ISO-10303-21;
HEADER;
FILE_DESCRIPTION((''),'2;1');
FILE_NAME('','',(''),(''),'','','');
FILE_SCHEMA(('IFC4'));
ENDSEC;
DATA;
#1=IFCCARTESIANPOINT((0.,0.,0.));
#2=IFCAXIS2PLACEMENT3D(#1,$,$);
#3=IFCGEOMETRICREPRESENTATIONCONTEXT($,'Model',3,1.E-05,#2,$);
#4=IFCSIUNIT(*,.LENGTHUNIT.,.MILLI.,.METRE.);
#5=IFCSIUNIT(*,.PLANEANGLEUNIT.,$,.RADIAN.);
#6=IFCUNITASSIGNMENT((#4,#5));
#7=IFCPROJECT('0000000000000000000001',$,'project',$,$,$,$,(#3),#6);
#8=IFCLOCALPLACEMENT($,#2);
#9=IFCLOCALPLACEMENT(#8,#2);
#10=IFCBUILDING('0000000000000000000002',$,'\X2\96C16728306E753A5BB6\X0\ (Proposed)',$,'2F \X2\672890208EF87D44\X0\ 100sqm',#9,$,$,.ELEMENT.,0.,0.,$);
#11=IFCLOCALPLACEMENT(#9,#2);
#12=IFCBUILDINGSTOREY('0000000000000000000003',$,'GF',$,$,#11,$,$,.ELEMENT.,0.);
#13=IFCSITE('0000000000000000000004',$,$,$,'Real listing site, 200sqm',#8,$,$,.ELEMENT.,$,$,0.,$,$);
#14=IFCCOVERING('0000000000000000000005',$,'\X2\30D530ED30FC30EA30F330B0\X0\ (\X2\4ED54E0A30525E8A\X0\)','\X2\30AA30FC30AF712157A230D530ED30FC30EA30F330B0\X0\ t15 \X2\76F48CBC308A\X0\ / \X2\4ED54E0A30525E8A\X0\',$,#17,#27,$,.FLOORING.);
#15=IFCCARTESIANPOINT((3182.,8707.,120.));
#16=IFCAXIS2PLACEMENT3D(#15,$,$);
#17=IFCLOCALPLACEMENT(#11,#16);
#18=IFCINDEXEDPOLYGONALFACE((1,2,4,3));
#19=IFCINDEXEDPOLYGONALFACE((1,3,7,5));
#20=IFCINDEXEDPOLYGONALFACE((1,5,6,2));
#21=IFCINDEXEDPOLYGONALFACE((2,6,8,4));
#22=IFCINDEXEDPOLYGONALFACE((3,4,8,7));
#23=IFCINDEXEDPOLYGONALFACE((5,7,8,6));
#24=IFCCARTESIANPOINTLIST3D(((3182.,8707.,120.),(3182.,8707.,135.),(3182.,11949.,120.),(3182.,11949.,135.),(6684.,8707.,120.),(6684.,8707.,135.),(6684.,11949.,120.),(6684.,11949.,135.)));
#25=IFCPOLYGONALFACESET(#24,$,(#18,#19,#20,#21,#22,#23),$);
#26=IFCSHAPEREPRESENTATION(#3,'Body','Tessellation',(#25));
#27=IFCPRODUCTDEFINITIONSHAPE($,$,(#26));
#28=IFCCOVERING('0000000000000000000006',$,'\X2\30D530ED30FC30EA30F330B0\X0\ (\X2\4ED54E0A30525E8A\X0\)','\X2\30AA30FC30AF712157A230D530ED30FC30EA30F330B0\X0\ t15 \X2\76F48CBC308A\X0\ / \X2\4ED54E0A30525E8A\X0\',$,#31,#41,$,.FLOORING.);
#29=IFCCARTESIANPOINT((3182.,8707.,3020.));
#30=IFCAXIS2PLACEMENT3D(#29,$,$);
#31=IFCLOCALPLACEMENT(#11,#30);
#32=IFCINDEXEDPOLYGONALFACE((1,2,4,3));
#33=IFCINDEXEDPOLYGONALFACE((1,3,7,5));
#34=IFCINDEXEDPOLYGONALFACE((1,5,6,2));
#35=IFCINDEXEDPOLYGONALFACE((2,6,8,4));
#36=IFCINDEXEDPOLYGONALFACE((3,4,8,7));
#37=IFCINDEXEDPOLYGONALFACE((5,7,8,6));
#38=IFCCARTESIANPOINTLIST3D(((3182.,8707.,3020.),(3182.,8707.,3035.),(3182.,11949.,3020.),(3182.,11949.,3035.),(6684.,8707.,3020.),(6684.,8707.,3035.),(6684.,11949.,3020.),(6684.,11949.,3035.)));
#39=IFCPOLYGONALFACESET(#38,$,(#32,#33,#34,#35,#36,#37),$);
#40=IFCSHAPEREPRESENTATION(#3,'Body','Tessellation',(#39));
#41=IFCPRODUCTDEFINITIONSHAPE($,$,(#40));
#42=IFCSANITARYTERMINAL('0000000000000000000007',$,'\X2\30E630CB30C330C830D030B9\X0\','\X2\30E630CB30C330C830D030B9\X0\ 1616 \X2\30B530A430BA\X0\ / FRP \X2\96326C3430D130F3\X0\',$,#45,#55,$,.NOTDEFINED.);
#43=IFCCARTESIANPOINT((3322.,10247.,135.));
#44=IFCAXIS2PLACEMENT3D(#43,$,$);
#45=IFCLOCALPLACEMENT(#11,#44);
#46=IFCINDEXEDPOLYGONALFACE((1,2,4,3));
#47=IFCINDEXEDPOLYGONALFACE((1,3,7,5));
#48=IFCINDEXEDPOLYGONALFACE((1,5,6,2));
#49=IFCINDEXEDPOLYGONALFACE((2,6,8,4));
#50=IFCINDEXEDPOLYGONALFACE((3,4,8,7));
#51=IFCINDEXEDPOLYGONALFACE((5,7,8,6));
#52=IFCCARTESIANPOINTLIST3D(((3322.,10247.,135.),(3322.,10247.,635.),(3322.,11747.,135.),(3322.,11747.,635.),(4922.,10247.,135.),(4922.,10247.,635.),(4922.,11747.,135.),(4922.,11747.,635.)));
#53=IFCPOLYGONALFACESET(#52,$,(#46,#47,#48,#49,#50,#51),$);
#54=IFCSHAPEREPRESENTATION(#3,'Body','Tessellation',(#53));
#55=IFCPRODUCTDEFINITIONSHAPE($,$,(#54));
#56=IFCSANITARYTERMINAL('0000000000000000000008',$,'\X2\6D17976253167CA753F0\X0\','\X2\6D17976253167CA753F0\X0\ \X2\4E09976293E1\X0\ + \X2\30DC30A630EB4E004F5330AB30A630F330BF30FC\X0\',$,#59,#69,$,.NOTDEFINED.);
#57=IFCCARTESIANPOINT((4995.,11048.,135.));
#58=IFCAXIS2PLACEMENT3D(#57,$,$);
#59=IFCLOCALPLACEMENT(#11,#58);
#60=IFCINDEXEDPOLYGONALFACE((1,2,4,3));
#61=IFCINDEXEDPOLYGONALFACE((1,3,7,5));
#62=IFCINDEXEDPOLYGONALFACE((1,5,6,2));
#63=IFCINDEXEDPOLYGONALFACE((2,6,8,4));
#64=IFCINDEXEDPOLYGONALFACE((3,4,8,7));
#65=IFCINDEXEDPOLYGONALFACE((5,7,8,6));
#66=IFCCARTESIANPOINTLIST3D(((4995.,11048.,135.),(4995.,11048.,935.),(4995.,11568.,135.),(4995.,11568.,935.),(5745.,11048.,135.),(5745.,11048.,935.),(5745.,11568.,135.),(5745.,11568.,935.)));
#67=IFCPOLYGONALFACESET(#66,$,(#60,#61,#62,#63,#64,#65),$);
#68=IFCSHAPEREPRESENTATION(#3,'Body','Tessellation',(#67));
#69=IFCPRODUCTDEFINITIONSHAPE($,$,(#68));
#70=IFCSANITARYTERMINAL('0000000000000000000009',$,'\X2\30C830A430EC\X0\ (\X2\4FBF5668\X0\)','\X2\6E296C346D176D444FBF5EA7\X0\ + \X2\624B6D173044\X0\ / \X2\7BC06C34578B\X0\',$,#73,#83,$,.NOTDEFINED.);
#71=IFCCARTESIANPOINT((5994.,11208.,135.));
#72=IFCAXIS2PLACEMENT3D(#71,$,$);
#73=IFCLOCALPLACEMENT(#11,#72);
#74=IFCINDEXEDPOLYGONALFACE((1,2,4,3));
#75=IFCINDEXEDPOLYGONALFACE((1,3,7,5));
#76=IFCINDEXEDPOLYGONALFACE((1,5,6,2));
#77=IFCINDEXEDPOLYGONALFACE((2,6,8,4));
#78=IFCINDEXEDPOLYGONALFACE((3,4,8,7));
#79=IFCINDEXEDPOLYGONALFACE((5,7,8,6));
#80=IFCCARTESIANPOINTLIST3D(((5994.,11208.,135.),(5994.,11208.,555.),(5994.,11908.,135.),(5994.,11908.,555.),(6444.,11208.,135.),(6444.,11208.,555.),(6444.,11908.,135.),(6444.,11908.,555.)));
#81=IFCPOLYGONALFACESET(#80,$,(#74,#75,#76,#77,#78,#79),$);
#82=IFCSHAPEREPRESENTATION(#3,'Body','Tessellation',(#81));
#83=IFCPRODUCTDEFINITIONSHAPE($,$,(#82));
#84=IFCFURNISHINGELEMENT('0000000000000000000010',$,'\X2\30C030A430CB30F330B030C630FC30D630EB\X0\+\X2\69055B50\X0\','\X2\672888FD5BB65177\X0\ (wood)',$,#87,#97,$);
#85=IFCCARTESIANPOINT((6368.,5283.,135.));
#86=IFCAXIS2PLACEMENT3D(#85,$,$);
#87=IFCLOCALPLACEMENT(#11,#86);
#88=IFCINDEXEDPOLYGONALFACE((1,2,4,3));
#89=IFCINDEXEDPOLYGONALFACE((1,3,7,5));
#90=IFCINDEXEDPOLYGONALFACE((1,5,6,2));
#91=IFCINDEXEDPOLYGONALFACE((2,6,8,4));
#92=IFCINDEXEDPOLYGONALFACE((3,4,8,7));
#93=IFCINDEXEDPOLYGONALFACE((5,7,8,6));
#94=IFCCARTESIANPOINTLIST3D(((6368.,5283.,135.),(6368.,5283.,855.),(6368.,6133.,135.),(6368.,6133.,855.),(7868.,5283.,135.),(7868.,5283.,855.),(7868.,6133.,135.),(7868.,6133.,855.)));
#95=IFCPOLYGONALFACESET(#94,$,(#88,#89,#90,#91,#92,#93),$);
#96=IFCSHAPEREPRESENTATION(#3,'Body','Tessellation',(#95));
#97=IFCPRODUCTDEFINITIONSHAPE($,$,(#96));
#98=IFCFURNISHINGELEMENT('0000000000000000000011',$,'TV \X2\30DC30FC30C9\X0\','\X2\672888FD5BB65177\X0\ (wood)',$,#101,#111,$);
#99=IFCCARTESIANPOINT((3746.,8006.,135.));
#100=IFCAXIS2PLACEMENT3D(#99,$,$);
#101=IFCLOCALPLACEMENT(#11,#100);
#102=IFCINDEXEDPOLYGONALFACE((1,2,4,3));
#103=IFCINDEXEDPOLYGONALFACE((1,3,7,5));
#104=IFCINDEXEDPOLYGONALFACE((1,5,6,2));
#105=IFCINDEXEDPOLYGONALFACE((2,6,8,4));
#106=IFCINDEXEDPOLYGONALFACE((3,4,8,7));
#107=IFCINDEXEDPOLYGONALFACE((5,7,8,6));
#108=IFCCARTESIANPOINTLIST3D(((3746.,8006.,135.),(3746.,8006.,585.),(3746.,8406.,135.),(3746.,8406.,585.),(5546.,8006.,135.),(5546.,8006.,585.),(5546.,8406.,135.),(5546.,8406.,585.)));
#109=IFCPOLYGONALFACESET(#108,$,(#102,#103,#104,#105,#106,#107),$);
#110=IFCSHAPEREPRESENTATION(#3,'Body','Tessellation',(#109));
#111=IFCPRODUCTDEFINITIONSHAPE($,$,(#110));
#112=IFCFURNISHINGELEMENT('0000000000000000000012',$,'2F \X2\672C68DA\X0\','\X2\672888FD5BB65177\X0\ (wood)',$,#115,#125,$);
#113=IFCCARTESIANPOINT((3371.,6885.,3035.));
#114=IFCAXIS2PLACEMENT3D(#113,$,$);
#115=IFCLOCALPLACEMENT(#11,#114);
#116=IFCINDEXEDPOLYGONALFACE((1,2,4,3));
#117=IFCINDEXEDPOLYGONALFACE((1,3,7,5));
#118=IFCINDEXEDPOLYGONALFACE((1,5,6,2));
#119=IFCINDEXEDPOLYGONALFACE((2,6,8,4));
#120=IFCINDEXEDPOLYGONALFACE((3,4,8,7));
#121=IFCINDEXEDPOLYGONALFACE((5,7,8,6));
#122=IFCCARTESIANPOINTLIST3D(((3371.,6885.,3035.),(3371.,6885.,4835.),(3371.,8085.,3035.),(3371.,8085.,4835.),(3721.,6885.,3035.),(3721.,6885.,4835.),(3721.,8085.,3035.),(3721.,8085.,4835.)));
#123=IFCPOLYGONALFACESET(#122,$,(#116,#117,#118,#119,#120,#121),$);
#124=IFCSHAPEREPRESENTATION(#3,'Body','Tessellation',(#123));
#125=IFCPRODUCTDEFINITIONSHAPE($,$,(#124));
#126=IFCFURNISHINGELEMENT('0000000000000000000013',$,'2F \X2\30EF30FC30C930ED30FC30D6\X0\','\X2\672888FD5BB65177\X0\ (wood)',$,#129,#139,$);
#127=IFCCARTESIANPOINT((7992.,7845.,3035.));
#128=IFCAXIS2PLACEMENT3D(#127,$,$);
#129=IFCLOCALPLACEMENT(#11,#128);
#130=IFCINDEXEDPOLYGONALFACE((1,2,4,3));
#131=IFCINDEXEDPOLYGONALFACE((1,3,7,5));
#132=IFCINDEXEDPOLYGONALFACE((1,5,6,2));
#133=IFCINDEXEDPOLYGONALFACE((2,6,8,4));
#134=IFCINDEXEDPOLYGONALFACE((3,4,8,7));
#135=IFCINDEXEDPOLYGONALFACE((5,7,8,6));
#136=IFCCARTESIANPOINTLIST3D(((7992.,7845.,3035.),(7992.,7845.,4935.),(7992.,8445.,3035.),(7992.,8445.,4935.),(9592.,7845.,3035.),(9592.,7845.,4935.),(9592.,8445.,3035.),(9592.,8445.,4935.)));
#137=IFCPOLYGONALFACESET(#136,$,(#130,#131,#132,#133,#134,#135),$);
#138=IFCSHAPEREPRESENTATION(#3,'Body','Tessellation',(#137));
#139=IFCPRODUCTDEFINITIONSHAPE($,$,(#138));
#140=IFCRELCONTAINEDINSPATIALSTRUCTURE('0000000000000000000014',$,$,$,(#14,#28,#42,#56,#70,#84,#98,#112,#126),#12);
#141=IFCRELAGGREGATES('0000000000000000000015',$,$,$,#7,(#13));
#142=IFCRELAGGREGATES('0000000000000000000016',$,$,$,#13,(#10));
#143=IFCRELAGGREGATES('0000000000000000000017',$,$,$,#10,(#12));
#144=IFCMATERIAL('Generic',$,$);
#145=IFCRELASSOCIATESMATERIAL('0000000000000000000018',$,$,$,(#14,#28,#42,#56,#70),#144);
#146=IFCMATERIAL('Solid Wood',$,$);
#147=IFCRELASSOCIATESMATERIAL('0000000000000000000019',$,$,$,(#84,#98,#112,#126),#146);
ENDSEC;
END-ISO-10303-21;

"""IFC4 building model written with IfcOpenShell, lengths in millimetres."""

from ifc_helpers import new_model, si_unit, frame, frame_2d, origin, place, context, project, spatial, rectangle, extrude, material, element, save


model = new_model("IFC4")

# Units and contexts
model_context = context("Model", 3, precision=1e-05, world=origin())
ifc_project = project(units=[si_unit("LENGTHUNIT", "METRE", prefix="MILLI"), si_unit("PLANEANGLEUNIT", "RADIAN")], contexts=[model_context])

# Site, building, storey
site_placement = place(None, origin())
site = spatial("IfcSite", under=ifc_project, at=site_placement, ObjectType="Real listing site, 200sqm", CompositionType="ELEMENT", RefElevation=0.0)
building_placement = place(site_placement, origin())
building = spatial("IfcBuilding", under=site, at=building_placement, Name="雁木の町家 (Proposed)", ObjectType="2F 木造軸組 100sqm", CompositionType="ELEMENT", ElevationOfRefHeight=0.0, ElevationOfTerrain=0.0)
storey_placement = place(building_placement, origin())
storey = spatial("IfcBuildingStorey", under=building, at=storey_placement, Name="GF", CompositionType="ELEMENT", Elevation=0.0)

# Shared definitions
ifc_material_1 = material(Name="Solid Wood")

# Coverings
ifc_material_2 = material(Name="Generic")
covering_1_placement = place(storey_placement, frame((3182.0, 8707.0, 120.0)))
element("IfcCovering", 1, at=covering_1_placement, inside=storey, material=ifc_material_2, Name="フローリング (仕上げ床)", Description="オーク無垢フローリング t15 直貼り / 仕上げ床", PredefinedType="FLOORING", context=model_context, shape_type="SweptSolid", body=[
    extrude(rectangle(XDim=3502.0, YDim=3242.0, at=frame_2d((1751.0, 1621.0))), frame((3182.0, 8707.0, 120.0)), (0.0, 0.0, 1.0), 15.0),
])
covering_2_placement = place(storey_placement, frame((3182.0, 8707.0, 3020.0)))
element("IfcCovering", 2, at=covering_2_placement, inside=storey, material=ifc_material_2, Name="フローリング (仕上げ床)", Description="オーク無垢フローリング t15 直貼り / 仕上げ床", PredefinedType="FLOORING", context=model_context, shape_type="SweptSolid", body=[
    extrude(rectangle(XDim=3502.0, YDim=3242.0, at=frame_2d((1751.0, 1621.0))), frame((3182.0, 8707.0, 3020.0)), (0.0, 0.0, 1.0), 15.0),
])

# Sanitary terminals
sanitary_terminal_1_placement = place(storey_placement, frame((3322.0, 10247.0, 135.0)))
element("IfcSanitaryTerminal", 3, at=sanitary_terminal_1_placement, inside=storey, material=ifc_material_2, Name="ユニットバス", Description="ユニットバス 1616 サイズ / FRP 防水パン", PredefinedType="NOTDEFINED", context=model_context, shape_type="SweptSolid", body=[
    extrude(rectangle(XDim=1600.0, YDim=1500.0, at=frame_2d((800.0, 750.0))), frame((3322.0, 10247.0, 135.0)), (0.0, 0.0, 1.0), 500.0),
])
sanitary_terminal_2_placement = place(storey_placement, frame((4995.0, 11048.0, 135.0)))
element("IfcSanitaryTerminal", 4, at=sanitary_terminal_2_placement, inside=storey, material=ifc_material_2, Name="洗面化粧台", Description="洗面化粧台 三面鏡 + ボウル一体カウンター", PredefinedType="NOTDEFINED", context=model_context, shape_type="SweptSolid", body=[
    extrude(rectangle(XDim=750.0, YDim=520.0, at=frame_2d((375.0, 260.0))), frame((4995.0, 11048.0, 135.0)), (0.0, 0.0, 1.0), 800.0),
])
sanitary_terminal_3_placement = place(storey_placement, frame((5994.0, 11208.0, 135.0)))
element("IfcSanitaryTerminal", 5, at=sanitary_terminal_3_placement, inside=storey, material=ifc_material_2, Name="トイレ (便器)", Description="温水洗浄便座 + 手洗い / 節水型", PredefinedType="NOTDEFINED", context=model_context, shape_type="SweptSolid", body=[
    extrude(rectangle(XDim=450.0, YDim=700.0, at=frame_2d((225.0, 350.0))), frame((5994.0, 11208.0, 135.0)), (0.0, 0.0, 1.0), 420.0),
])

# Furnishing elements
furnishing_1_placement = place(storey_placement, frame((6368.0, 5283.0, 135.0)))
element("IfcFurnishingElement", 6, at=furnishing_1_placement, inside=storey, material=ifc_material_1, Name="ダイニングテーブル+椅子", Description="木製家具 (wood)", context=model_context, shape_type="SweptSolid", body=[
    extrude(rectangle(XDim=1500.0, YDim=850.0, at=frame_2d((750.0, 425.0))), frame((6368.0, 5283.0, 135.0)), (0.0, 0.0, 1.0), 720.0),
])
furnishing_2_placement = place(storey_placement, frame((3746.0, 8006.0, 135.0)))
element("IfcFurnishingElement", 7, at=furnishing_2_placement, inside=storey, material=ifc_material_1, Name="TV ボード", Description="木製家具 (wood)", context=model_context, shape_type="SweptSolid", body=[
    extrude(rectangle(XDim=1800.0, YDim=400.0, at=frame_2d((900.0, 200.0))), frame((3746.0, 8006.0, 135.0)), (0.0, 0.0, 1.0), 450.0),
])
furnishing_3_placement = place(storey_placement, frame((3371.0, 6885.0, 3035.0)))
element("IfcFurnishingElement", 8, at=furnishing_3_placement, inside=storey, material=ifc_material_1, Name="2F 本棚", Description="木製家具 (wood)", context=model_context, shape_type="SweptSolid", body=[
    extrude(rectangle(XDim=350.0, YDim=1200.0, at=frame_2d((175.0, 600.0))), frame((3371.0, 6885.0, 3035.0)), (0.0, 0.0, 1.0), 1800.0),
])
furnishing_4_placement = place(storey_placement, frame((7992.0, 7845.0, 3035.0)))
element("IfcFurnishingElement", 9, at=furnishing_4_placement, inside=storey, material=ifc_material_1, Name="2F ワードローブ", Description="木製家具 (wood)", context=model_context, shape_type="SweptSolid", body=[
    extrude(rectangle(XDim=1600.0, YDim=600.0, at=frame_2d((800.0, 300.0))), frame((7992.0, 7845.0, 3035.0)), (0.0, 0.0, 1.0), 1900.0),
])

save(model, "model.ifc")
